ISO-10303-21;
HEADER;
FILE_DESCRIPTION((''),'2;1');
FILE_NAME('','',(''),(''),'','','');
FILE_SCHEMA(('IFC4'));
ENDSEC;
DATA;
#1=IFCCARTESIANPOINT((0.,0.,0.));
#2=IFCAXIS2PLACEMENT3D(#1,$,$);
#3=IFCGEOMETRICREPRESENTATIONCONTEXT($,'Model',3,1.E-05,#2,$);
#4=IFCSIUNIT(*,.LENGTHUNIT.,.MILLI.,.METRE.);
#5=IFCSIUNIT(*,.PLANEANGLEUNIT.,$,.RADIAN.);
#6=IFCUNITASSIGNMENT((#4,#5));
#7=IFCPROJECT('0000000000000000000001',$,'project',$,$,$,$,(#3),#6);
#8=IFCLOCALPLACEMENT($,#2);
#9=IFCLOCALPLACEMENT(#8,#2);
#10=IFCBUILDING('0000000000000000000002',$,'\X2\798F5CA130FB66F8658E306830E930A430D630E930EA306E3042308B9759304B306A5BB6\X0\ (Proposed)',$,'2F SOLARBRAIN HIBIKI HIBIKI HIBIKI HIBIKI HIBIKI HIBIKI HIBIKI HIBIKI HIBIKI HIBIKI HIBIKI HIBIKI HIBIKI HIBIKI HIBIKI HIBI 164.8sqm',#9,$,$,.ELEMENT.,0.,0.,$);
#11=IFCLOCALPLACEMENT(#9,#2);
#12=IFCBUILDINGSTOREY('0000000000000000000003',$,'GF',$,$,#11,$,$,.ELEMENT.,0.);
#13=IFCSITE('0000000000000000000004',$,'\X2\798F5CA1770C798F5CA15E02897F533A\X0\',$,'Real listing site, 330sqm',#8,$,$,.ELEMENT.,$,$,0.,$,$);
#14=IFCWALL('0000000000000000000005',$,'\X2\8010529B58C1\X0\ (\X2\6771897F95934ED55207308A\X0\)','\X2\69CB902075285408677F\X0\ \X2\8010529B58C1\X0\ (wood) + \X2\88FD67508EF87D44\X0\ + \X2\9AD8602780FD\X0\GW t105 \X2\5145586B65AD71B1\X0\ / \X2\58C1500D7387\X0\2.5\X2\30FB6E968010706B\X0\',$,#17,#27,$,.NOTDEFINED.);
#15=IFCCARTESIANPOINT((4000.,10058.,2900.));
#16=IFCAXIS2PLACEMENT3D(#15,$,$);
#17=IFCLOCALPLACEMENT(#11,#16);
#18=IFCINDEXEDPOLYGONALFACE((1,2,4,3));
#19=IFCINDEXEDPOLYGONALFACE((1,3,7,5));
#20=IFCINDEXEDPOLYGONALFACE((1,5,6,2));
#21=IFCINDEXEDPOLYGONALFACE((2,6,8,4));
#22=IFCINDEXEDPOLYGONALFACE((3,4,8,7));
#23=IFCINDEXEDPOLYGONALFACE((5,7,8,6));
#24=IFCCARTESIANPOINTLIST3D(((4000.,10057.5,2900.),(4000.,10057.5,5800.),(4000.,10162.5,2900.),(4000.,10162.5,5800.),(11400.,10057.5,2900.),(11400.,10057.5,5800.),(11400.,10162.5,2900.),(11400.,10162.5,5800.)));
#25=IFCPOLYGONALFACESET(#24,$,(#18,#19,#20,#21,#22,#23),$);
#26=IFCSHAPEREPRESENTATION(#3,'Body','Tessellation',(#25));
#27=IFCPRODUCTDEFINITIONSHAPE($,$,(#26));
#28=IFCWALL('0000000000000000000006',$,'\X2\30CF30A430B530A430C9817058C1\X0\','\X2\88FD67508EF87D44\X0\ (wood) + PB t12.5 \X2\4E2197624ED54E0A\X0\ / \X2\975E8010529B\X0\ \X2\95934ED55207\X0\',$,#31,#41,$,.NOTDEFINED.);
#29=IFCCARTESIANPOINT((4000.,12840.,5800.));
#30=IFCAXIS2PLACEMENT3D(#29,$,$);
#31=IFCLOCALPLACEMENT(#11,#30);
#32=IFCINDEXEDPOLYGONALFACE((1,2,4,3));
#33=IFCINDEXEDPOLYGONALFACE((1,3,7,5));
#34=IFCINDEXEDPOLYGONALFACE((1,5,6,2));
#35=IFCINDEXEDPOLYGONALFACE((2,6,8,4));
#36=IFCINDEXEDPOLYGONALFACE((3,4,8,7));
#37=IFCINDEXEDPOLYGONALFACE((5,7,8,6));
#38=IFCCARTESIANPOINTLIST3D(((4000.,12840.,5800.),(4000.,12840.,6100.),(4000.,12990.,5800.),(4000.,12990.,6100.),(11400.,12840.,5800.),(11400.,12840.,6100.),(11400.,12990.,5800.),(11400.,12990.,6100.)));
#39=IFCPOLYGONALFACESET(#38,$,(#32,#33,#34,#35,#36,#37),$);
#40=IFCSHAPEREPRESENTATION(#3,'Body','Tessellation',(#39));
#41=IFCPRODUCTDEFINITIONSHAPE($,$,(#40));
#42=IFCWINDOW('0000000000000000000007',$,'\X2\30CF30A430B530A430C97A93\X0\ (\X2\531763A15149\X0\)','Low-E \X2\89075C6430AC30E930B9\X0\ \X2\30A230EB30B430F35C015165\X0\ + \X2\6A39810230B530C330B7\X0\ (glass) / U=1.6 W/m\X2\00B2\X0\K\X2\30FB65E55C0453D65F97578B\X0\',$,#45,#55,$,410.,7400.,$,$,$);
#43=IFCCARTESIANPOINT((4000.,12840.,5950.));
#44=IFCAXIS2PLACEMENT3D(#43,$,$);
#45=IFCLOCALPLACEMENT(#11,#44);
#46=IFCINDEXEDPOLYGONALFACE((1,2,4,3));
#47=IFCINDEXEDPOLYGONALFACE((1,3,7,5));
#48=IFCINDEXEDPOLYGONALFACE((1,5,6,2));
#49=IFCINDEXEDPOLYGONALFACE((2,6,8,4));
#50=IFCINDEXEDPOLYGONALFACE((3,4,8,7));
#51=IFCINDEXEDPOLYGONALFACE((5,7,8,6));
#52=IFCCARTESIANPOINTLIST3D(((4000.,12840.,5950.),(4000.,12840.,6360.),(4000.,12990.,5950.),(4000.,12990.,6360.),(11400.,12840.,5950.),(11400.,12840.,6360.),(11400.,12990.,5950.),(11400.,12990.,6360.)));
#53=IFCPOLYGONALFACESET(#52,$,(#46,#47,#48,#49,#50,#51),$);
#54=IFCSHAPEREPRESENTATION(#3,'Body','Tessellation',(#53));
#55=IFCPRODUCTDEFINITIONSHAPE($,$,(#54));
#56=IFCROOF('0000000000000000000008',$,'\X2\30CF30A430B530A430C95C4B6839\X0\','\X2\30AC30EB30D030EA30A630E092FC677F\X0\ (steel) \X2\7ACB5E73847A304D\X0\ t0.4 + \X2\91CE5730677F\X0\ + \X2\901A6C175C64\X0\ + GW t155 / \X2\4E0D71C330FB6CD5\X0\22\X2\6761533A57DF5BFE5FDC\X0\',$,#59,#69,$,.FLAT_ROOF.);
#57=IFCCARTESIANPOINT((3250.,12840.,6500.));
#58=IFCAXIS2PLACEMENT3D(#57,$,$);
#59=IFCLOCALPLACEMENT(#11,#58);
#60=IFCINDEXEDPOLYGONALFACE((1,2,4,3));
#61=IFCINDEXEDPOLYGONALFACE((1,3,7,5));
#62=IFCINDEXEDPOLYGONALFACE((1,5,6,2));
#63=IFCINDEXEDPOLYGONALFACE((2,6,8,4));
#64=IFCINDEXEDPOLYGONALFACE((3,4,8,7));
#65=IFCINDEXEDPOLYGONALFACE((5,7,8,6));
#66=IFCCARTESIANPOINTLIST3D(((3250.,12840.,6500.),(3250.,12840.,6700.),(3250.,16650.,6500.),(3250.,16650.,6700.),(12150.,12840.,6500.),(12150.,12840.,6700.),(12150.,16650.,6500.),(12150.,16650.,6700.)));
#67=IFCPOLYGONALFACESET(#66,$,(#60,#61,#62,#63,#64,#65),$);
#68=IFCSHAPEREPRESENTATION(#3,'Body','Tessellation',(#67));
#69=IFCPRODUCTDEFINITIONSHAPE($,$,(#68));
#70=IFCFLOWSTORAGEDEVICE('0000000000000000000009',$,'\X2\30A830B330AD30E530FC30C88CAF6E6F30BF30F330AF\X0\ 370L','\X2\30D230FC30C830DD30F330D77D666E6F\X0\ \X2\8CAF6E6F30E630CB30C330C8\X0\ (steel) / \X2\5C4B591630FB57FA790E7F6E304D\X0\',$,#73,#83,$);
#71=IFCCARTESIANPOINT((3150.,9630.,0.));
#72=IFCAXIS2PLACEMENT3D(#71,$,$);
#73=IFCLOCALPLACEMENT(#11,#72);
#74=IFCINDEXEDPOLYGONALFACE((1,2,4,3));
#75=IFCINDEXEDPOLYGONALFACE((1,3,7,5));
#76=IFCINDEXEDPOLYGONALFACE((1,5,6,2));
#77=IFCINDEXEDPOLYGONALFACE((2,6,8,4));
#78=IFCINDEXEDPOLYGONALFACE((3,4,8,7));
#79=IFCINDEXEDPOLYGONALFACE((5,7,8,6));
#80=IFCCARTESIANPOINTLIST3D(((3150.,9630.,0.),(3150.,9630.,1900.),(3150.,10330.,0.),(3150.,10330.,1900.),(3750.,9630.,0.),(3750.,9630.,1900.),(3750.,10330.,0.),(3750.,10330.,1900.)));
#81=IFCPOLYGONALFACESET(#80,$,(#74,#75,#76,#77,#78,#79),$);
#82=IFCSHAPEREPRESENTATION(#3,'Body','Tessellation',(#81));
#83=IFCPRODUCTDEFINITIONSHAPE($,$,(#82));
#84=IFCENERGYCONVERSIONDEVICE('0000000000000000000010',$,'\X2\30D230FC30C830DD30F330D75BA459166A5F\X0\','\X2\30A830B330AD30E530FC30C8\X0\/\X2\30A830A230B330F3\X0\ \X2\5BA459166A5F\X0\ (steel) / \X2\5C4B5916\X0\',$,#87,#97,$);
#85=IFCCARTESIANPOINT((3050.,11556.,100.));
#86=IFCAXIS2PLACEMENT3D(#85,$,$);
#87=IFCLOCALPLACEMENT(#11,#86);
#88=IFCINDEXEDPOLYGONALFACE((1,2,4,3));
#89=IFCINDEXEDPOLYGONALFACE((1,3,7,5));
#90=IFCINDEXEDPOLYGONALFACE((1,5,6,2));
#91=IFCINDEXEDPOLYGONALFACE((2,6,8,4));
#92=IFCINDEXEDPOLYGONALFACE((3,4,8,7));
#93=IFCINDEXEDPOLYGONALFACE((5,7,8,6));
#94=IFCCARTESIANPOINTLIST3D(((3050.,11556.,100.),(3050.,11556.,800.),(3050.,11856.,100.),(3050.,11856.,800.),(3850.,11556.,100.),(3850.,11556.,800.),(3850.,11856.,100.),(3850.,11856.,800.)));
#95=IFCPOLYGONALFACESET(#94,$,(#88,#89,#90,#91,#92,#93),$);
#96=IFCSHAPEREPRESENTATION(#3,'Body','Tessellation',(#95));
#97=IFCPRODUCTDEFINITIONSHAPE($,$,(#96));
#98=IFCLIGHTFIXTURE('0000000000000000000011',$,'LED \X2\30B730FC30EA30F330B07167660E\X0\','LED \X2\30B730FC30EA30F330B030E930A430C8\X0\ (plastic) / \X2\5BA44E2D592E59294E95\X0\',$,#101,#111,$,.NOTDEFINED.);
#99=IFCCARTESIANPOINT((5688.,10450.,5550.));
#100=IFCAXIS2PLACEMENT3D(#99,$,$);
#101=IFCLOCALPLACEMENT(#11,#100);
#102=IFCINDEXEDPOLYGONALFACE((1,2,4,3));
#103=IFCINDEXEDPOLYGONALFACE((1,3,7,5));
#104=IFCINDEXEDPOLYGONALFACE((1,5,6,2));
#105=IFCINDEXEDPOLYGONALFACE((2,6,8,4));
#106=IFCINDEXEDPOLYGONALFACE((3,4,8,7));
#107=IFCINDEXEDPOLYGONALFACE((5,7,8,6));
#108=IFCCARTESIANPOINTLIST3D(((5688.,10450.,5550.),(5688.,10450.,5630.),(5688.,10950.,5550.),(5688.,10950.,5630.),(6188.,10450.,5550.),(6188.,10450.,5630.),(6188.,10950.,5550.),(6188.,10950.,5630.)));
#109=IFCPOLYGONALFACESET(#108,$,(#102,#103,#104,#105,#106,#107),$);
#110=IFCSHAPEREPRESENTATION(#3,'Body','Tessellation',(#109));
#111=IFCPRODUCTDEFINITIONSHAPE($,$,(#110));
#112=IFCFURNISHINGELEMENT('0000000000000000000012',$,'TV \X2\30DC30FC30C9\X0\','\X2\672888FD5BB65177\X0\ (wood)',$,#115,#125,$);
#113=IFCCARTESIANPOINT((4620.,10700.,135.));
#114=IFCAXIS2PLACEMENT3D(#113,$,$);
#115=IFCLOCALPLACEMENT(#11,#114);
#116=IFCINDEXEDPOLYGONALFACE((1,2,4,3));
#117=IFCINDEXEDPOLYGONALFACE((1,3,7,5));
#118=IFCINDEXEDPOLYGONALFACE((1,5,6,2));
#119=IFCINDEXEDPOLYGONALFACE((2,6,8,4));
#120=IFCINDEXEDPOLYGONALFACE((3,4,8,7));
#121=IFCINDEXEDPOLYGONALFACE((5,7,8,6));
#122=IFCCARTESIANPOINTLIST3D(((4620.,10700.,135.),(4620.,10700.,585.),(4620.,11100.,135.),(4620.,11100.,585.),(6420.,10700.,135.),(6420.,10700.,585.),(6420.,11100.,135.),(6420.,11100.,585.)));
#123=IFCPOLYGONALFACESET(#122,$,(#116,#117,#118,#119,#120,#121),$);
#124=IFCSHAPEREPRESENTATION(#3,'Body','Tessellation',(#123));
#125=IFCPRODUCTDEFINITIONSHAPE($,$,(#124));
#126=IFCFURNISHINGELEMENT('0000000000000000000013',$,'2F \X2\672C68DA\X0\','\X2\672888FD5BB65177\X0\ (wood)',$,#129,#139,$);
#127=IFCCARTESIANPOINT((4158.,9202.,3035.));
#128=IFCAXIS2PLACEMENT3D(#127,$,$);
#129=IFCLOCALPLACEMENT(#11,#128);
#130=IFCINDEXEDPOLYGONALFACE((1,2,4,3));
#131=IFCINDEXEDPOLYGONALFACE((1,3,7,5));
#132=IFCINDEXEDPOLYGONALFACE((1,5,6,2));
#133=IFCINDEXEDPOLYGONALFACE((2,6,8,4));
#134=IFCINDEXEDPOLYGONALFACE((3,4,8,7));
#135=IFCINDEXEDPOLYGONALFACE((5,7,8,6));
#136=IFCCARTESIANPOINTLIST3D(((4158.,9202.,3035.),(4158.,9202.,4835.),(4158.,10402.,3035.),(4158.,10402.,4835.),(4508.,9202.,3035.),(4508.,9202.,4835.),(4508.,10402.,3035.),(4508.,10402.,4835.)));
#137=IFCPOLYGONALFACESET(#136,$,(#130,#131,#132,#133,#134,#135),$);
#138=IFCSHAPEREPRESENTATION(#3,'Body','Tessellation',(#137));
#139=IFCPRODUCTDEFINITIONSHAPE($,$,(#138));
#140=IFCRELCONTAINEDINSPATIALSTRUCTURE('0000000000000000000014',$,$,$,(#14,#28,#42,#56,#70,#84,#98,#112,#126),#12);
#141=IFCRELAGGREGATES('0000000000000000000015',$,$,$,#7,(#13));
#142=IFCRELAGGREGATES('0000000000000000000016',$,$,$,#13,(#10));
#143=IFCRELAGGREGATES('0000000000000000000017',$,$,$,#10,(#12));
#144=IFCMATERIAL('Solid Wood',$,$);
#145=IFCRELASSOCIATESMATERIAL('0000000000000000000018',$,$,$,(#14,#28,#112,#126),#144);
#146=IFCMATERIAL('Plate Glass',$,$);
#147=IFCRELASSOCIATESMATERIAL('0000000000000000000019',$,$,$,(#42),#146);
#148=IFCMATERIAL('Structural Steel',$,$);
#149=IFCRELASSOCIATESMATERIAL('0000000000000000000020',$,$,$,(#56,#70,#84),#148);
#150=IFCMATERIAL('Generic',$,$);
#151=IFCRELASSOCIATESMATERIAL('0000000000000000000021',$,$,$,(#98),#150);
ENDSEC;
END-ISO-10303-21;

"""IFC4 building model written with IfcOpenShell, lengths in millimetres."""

from ifc_helpers import new_model, si_unit, frame, frame_2d, origin, place, context, project, spatial, rectangle, extrude, material, element, fill, save


model = new_model("IFC4")

# Units and contexts
model_context = context("Model", 3, precision=1e-05, world=origin())
ifc_project = project(units=[si_unit("LENGTHUNIT", "METRE", prefix="MILLI"), si_unit("PLANEANGLEUNIT", "RADIAN")], contexts=[model_context])

# Site, building, storey
site_placement = place(None, origin())
site = spatial("IfcSite", under=ifc_project, at=site_placement, Name="福岡県福岡市西区", ObjectType="Real listing site, 330sqm", CompositionType="ELEMENT", RefElevation=0.0)
building_placement = place(site_placement, origin())
building = spatial("IfcBuilding", under=site, at=building_placement, Name="福岡・書斎とライブラリのある静かな家 (Proposed)", ObjectType="2F SOLARBRAIN HIBIKI HIBIKI HIBIKI HIBIKI HIBIKI HIBIKI HIBIKI HIBIKI HIBIKI HIBIKI HIBIKI HIBIKI HIBIKI HIBIKI HIBIKI HIBI 164.8sqm", CompositionType="ELEMENT", ElevationOfRefHeight=0.0, ElevationOfTerrain=0.0)
storey_placement = place(building_placement, origin())
storey = spatial("IfcBuildingStorey", under=building, at=storey_placement, Name="GF", CompositionType="ELEMENT", Elevation=0.0)

# Shared definitions
ifc_material_1 = material(Name="Solid Wood")

# Wall
wall_1_placement = place(storey_placement, frame((4000.0, 10058.0, 2900.0)))
element("IfcWall", 1, at=wall_1_placement, inside=storey, material=ifc_material_1, Name="耐力壁 (東西間仕切り)", Description="構造用合板 耐力壁 (wood) + 製材軸組 + 高性能GW t105 充填断熱 / 壁倍率2.5・準耐火", PredefinedType="NOTDEFINED", context=model_context, shape_type="SweptSolid", body=[
    extrude(rectangle(XDim=7400.0, YDim=105.0, at=frame_2d((3700.0, 52.0))), frame((4000.0, 10058.0, 2900.0)), (0.0, 0.0, 1.0), 2900.0),
])

# Wall, opening, window
wall_2_placement = place(storey_placement, frame((4000.0, 12840.0, 5800.0)))
wall_2 = element("IfcWall", 2, at=wall_2_placement, inside=storey, material=ifc_material_1, Name="ハイサイド腰壁", Description="製材軸組 (wood) + PB t12.5 両面仕上 / 非耐力 間仕切", PredefinedType="NOTDEFINED", context=model_context, shape_type="SweptSolid", body=[
    extrude(rectangle(XDim=7400.0, YDim=150.0, at=frame_2d((3700.0, 75.0))), frame((4000.0, 12840.0, 5800.0)), (0.0, 0.0, 1.0), 700.0),
])
opening_1_placement = place(storey_placement, frame((4000.0, 12840.0, 5950.0)))
opening_1 = element("IfcOpeningElement", 3, at=opening_1_placement, cuts=wall_2, PredefinedType="NOTDEFINED", context=model_context, shape_type="SweptSolid", body=[
    extrude(rectangle(XDim=7400.0, YDim=150.0, at=frame_2d((3700.0, 75.0))), frame((4000.0, 12840.0, 5950.0)), (0.0, 0.0, 1.0), 410.0),
])
ifc_material_2 = material(Name="Plate Glass")
window_placement = place(storey_placement, frame((4000.0, 12840.0, 5950.0)))
window = element("IfcWindow", 4, at=window_placement, inside=storey, material=ifc_material_2, Name="ハイサイド窓 (北採光)", Description="Low-E 複層ガラス アルゴン封入 + 樹脂サッシ (glass) / U=1.6 W/m²K・日射取得型", OverallHeight=410.0, OverallWidth=7400.0, context=model_context, shape_type="SweptSolid", body=[
    extrude(rectangle(XDim=7400.0, YDim=150.0, at=frame_2d((3700.0, 75.0))), frame((4000.0, 12840.0, 5950.0)), (0.0, 0.0, 1.0), 410.0),
])
fill(opening_1, window)

# Roof
ifc_material_3 = material(Name="Structural Steel")
roof_placement = place(storey_placement, frame((3250.0, 12840.0, 6500.0)))
element("IfcRoof", 5, at=roof_placement, inside=storey, material=ifc_material_3, Name="ハイサイド屋根", Description="ガルバリウム鋼板 (steel) 立平葺き t0.4 + 野地板 + 通気層 + GW t155 / 不燃・法22条区域対応", PredefinedType="FLAT_ROOF", context=model_context, shape_type="SweptSolid", body=[
    extrude(rectangle(XDim=8900.0, YDim=3810.0, at=frame_2d((4450.0, 1905.0))), frame((3250.0, 12840.0, 6500.0)), (0.0, 0.0, 1.0), 200.0),
])

# Flow storage device
flow_storage_device_placement = place(storey_placement, frame((3150.0, 9630.0, 0.0)))
element("IfcFlowStorageDevice", 6, at=flow_storage_device_placement, inside=storey, material=ifc_material_3, Name="エコキュート貯湯タンク 370L", Description="ヒートポンプ給湯 貯湯ユニット (steel) / 屋外・基礎置き", context=model_context, shape_type="SweptSolid", body=[
    extrude(rectangle(XDim=600.0, YDim=700.0, at=frame_2d((300.0, 350.0))), frame((3150.0, 9630.0, 0.0)), (0.0, 0.0, 1.0), 1900.0),
])

# Energy conversion device
energy_conversion_device_placement = place(storey_placement, frame((3050.0, 11556.0, 100.0)))
element("IfcEnergyConversionDevice", 7, at=energy_conversion_device_placement, inside=storey, material=ifc_material_3, Name="ヒートポンプ室外機", Description="エコキュート/エアコン 室外機 (steel) / 屋外", context=model_context, shape_type="SweptSolid", body=[
    extrude(rectangle(XDim=800.0, YDim=300.0, at=frame_2d((400.0, 150.0))), frame((3050.0, 11556.0, 100.0)), (0.0, 0.0, 1.0), 700.0),
])

# Light fixture
ifc_material_4 = material(Name="Generic")
light_fixture_placement = place(storey_placement, frame((5688.0, 10450.0, 5550.0)))
element("IfcLightFixture", 8, at=light_fixture_placement, inside=storey, material=ifc_material_4, Name="LED シーリング照明", Description="LED シーリングライト (plastic) / 室中央天井", PredefinedType="NOTDEFINED", context=model_context, shape_type="SweptSolid", body=[
    extrude(rectangle(XDim=500.0, YDim=500.0, at=frame_2d((250.0, 250.0))), frame((5688.0, 10450.0, 5550.0)), (0.0, 0.0, 1.0), 80.0),
])

# Furnishing elements
furnishing_1_placement = place(storey_placement, frame((4620.0, 10700.0, 135.0)))
element("IfcFurnishingElement", 9, at=furnishing_1_placement, inside=storey, material=ifc_material_1, Name="TV ボード", Description="木製家具 (wood)", context=model_context, shape_type="SweptSolid", body=[
    extrude(rectangle(XDim=1800.0, YDim=400.0, at=frame_2d((900.0, 200.0))), frame((4620.0, 10700.0, 135.0)), (0.0, 0.0, 1.0), 450.0),
])
furnishing_2_placement = place(storey_placement, frame((4158.0, 9202.0, 3035.0)))
element("IfcFurnishingElement", 10, at=furnishing_2_placement, inside=storey, material=ifc_material_1, Name="2F 本棚", Description="木製家具 (wood)", context=model_context, shape_type="SweptSolid", body=[
    extrude(rectangle(XDim=350.0, YDim=1200.0, at=frame_2d((175.0, 600.0))), frame((4158.0, 9202.0, 3035.0)), (0.0, 0.0, 1.0), 1800.0),
])

save(model, "model.ifc")
